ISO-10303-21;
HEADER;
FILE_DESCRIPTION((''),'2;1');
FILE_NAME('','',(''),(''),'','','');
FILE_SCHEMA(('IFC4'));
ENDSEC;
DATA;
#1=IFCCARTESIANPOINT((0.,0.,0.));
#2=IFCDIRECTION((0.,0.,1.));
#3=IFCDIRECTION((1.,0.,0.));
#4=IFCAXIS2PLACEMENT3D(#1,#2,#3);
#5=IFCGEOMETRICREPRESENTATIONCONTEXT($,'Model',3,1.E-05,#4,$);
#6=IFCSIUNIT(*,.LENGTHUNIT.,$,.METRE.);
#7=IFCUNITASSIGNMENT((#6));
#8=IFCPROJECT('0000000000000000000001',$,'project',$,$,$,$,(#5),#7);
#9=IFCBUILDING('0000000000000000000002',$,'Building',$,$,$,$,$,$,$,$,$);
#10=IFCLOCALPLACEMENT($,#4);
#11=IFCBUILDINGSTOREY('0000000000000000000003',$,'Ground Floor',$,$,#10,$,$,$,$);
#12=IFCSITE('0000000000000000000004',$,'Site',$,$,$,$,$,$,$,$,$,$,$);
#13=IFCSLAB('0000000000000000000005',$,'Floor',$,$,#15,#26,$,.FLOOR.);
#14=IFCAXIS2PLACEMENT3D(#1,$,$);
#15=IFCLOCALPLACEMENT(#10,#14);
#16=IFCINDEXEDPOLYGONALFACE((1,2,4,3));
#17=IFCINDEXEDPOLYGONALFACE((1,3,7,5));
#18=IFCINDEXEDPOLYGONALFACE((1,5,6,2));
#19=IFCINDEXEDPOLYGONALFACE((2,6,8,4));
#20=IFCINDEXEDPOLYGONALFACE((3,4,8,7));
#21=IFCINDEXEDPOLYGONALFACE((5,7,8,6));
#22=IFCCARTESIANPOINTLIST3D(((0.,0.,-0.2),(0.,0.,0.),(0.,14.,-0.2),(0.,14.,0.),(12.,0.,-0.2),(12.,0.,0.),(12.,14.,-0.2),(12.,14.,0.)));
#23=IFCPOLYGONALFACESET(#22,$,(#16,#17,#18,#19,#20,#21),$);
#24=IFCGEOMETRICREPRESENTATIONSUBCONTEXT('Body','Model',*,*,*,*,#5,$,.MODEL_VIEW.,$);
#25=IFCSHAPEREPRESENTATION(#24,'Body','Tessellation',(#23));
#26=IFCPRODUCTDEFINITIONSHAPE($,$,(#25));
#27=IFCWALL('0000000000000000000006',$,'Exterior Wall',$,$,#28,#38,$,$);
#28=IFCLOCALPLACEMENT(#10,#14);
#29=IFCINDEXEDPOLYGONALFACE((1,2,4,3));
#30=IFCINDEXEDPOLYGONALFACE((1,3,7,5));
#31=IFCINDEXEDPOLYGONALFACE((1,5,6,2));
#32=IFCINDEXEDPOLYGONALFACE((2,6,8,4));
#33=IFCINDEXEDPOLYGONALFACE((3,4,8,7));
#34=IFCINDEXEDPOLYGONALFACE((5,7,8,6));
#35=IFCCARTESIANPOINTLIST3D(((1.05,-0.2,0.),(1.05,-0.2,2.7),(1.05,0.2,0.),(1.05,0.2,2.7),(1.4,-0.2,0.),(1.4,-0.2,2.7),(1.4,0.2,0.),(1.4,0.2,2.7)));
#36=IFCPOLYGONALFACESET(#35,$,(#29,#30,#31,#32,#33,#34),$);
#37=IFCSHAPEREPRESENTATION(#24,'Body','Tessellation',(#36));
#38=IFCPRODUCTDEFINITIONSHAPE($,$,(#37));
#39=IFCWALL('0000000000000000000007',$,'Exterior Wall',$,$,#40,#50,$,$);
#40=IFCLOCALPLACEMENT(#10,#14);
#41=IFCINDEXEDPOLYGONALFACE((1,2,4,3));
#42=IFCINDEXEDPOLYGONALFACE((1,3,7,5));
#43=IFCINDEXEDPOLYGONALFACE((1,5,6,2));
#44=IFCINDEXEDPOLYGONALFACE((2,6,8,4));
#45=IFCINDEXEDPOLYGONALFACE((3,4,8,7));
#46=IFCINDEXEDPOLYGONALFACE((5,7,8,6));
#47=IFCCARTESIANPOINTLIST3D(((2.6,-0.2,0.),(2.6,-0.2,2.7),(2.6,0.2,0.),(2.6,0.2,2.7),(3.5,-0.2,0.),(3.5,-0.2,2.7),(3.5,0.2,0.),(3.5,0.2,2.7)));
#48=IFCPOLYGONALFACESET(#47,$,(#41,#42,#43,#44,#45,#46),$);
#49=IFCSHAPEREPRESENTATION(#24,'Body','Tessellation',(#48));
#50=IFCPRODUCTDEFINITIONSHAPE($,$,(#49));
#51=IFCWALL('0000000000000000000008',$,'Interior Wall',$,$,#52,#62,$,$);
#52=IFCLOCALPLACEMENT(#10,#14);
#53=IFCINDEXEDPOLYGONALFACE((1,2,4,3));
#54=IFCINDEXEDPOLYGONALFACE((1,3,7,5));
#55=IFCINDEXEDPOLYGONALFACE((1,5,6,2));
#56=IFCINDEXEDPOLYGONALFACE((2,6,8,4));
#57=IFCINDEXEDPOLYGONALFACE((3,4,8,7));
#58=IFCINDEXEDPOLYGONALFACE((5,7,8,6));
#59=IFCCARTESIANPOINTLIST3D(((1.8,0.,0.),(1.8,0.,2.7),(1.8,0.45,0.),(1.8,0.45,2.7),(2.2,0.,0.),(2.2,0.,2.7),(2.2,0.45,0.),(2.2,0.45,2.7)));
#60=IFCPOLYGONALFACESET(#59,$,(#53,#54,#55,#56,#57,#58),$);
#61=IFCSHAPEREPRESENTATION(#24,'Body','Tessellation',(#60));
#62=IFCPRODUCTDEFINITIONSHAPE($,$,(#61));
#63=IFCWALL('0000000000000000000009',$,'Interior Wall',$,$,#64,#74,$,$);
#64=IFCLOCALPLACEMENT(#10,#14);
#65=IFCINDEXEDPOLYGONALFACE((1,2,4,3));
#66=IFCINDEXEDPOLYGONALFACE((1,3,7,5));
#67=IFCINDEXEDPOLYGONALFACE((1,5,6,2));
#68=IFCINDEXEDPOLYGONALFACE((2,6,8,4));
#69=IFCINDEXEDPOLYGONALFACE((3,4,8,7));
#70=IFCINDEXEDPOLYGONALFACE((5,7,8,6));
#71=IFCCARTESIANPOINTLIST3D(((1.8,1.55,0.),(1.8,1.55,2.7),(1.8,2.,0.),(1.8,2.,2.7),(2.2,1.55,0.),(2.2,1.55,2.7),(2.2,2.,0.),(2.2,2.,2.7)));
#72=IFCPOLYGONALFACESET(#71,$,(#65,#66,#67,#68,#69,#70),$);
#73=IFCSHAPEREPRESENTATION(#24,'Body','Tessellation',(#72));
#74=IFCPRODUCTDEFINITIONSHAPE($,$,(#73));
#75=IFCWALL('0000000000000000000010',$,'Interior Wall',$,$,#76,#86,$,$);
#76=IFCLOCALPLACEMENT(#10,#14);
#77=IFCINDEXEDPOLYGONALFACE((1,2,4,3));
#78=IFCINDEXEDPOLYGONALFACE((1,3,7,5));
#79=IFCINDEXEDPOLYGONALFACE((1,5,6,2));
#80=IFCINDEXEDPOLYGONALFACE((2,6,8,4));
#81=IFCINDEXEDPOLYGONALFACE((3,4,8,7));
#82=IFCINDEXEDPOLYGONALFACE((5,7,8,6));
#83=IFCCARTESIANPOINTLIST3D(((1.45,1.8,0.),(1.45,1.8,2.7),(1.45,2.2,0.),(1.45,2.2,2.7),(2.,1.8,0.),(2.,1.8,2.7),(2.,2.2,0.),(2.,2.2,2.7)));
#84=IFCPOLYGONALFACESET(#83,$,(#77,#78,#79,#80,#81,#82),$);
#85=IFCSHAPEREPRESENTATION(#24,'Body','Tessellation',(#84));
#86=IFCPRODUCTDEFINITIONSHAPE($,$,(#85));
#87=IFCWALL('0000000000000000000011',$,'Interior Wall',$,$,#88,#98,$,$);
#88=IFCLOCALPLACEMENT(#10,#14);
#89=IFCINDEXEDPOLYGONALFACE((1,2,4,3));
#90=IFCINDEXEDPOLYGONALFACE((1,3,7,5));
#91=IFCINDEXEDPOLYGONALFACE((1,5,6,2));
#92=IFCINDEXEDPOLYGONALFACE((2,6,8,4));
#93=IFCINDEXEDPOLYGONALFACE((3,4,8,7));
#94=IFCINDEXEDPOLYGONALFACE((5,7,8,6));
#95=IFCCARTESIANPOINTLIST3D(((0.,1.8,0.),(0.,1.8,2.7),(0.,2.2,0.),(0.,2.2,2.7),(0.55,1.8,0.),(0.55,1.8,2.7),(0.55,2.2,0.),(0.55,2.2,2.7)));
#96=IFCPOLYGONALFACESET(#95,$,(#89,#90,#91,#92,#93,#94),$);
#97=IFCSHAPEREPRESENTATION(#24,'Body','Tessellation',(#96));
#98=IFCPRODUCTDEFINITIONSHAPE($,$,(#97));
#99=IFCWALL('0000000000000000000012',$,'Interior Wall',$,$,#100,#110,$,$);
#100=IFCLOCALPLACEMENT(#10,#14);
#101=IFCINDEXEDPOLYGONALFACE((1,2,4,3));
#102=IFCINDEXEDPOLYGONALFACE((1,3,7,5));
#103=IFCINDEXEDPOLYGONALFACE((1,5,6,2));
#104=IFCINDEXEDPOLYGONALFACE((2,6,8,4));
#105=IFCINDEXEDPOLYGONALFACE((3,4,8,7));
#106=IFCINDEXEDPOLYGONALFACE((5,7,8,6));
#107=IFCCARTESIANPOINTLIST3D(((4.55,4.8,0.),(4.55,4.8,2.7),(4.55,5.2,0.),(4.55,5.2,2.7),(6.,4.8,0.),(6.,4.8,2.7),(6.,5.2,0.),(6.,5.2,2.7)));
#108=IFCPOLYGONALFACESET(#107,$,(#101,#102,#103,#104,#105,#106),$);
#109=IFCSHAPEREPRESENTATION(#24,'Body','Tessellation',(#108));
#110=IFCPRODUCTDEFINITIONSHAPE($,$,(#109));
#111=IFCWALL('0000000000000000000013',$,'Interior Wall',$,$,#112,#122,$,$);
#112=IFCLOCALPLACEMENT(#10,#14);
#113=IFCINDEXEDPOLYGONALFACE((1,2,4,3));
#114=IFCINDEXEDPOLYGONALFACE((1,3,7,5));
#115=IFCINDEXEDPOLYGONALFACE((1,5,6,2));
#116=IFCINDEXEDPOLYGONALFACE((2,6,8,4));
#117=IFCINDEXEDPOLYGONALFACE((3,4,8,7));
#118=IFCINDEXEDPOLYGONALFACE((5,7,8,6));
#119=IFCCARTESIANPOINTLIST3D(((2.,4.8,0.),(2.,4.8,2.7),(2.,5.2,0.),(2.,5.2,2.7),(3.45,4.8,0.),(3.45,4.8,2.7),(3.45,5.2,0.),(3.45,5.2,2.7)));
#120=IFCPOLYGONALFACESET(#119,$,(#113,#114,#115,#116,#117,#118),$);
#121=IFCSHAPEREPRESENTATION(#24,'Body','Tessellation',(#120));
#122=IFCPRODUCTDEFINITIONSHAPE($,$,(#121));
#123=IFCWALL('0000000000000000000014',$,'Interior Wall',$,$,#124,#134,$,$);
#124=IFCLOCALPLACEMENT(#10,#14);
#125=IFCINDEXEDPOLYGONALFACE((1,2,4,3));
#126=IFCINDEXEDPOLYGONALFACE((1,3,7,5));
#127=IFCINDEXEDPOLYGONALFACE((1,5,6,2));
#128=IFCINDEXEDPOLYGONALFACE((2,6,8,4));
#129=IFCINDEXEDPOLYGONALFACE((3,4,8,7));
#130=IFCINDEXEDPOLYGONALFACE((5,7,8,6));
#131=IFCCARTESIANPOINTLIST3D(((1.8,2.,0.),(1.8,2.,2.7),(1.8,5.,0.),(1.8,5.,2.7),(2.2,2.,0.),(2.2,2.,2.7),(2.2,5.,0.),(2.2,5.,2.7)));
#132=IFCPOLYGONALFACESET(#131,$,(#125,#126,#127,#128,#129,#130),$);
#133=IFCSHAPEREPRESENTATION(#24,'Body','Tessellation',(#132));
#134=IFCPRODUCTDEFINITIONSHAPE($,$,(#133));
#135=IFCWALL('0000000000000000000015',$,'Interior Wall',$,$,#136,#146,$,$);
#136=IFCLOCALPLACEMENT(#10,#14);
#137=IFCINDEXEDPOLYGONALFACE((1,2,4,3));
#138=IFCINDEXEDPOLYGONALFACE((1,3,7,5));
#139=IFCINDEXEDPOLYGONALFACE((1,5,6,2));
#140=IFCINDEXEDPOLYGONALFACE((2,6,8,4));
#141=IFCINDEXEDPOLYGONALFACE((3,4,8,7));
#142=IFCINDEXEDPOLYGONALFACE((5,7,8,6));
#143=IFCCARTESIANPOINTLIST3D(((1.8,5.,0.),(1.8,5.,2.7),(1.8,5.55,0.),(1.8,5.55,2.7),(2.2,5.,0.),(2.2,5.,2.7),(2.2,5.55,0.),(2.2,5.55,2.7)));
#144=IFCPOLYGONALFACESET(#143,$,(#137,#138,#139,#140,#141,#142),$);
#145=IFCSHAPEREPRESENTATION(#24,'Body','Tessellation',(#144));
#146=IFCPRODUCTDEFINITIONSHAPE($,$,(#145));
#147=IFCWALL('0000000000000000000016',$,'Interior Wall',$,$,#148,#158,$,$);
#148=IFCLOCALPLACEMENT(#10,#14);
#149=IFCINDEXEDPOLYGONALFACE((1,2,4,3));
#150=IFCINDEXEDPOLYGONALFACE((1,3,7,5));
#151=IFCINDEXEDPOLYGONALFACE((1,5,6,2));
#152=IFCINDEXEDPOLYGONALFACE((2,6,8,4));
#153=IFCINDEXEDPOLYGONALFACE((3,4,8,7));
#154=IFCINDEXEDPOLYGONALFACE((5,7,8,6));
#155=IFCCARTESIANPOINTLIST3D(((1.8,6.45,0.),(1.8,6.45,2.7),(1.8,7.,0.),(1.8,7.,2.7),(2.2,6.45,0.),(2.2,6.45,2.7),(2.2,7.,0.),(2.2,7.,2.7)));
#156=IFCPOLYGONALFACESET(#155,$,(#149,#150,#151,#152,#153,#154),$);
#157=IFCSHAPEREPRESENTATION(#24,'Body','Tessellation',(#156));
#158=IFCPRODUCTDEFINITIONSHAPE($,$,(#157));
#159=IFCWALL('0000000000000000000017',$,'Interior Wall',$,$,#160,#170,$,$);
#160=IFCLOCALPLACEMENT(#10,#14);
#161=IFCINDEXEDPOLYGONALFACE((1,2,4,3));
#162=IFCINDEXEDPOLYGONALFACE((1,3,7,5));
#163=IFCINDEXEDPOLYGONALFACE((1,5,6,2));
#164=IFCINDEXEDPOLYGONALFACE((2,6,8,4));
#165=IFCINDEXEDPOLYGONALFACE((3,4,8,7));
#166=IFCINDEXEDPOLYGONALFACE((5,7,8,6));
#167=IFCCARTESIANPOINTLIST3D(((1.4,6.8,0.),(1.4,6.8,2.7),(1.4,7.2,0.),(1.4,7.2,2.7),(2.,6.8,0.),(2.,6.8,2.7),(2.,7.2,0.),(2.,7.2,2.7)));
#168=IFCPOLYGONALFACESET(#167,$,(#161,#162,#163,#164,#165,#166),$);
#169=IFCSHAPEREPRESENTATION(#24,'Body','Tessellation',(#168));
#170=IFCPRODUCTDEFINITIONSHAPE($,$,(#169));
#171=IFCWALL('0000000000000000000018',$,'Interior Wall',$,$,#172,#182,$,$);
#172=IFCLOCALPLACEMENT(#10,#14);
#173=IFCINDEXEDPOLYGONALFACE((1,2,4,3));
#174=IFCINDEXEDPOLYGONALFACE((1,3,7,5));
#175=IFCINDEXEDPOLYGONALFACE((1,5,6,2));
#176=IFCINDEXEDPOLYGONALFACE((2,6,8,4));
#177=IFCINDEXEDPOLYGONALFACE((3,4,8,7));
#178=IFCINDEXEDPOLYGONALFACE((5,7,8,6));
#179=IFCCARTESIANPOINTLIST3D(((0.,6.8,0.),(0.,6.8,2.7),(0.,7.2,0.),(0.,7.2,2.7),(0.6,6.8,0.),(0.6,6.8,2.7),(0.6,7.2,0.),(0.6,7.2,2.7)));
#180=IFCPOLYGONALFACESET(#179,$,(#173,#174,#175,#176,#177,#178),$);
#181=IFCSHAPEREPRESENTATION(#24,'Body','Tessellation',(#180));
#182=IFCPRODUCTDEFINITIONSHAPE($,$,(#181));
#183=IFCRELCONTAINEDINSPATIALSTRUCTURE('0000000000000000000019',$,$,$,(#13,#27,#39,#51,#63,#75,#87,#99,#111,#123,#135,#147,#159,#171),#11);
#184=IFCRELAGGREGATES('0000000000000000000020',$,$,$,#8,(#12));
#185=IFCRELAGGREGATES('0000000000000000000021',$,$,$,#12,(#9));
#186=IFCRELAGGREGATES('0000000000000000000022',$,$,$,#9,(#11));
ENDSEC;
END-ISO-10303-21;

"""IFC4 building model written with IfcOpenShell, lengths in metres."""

from ifc_helpers import new_model, si_unit, frame, origin_with_axes, place, context, subcontext, project, spatial, indexed_curve, outline, extrude, element, save


model = new_model("IFC4")

# Units and contexts
model_context = context("Model", 3, precision=1e-05, world=origin_with_axes())
body_context = subcontext(model_context, "Body", "Model", "MODEL_VIEW")
ifc_project = project(units=[si_unit("LENGTHUNIT", "METRE")], contexts=[model_context])

# Site, building, storey
site = spatial("IfcSite", under=ifc_project, Name="Site")
building = spatial("IfcBuilding", under=site, Name="Building")
storey_placement = place(None, origin_with_axes())
storey = spatial("IfcBuildingStorey", under=building, at=storey_placement, Name="Ground Floor")

# Slab
slab_placement = place(storey_placement, frame((0.0, 0.0, -0.2), z_axis=(0.0, 0.0, 1.0), x_axis=(1.0, 0.0, 0.0)))
element("IfcSlab", 1, at=slab_placement, inside=storey, Name="Floor", PredefinedType="FLOOR", context=body_context, shape_type="SweptSolid", body=[
    extrude(outline(indexed_curve([(0.0, 0.0), (12.0, 0.0), (12.0, 14.0), (0.0, 14.0)])), None, (0.0, 0.0, 1.0), 0.2),
])

# Walls
wall_1_placement = place(storey_placement, frame((1.05, 0.0, 0.0), z_axis=(0.0, 0.0, 1.0), x_axis=(1.0, 0.0, 0.0)))
element("IfcWall", 2, at=wall_1_placement, inside=storey, Name="Exterior Wall", context=body_context, shape_type="SweptSolid", body=[
    extrude(outline(indexed_curve([(0.0, 0.0), (0.0, 0.4), (0.35, 0.4), (0.35, 0.0), (0.0, 0.0)], self_intersect=False)), frame((0.0, -0.2, 0.0), z_axis=(0.0, 0.0, 1.0), x_axis=(1.0, 0.0, 0.0)), (0.0, 0.0, 1.0), 2.7),
])
wall_2_placement = place(storey_placement, frame((2.6, 0.0, 0.0), z_axis=(0.0, 0.0, 1.0), x_axis=(1.0, 0.0, 0.0)))
element("IfcWall", 3, at=wall_2_placement, inside=storey, Name="Exterior Wall", context=body_context, shape_type="SweptSolid", body=[
    extrude(outline(indexed_curve([(0.0, 0.0), (0.0, 0.4), (0.9, 0.4), (0.9, 0.0), (0.0, 0.0)], self_intersect=False)), frame((0.0, -0.2, 0.0), z_axis=(0.0, 0.0, 1.0), x_axis=(1.0, 0.0, 0.0)), (0.0, 0.0, 1.0), 2.7),
])
for number, where, z_axis, x_axis, name in (
    (4, (2.0, 0.0, 0.0), (0.0, 0.0, 1.0), (0.0, 1.0, 0.0), "Interior Wall"),
    (5, (2.0, 1.55, 0.0), (0.0, 0.0, 1.0), (0.0, 1.0, 0.0), "Interior Wall"),
):
    element("IfcWall", number, at=place(storey_placement, frame(where, z_axis=z_axis, x_axis=x_axis)), inside=storey, Name=name, context=body_context, shape_type="SweptSolid", body=[
        extrude(outline(indexed_curve([(0.0, 0.0), (0.0, 0.4), (0.45, 0.4), (0.45, 0.0), (0.0, 0.0)], self_intersect=False)), frame((0.0, -0.2, 0.0), z_axis=(0.0, 0.0, 1.0), x_axis=(1.0, 0.0, 0.0)), (0.0, 0.0, 1.0), 2.7),
    ])
for number, where, z_axis, x_axis, name in (
    (6, (2.0, 2.0, 0.0), (0.0, 0.0, 1.0), (-1.0, 0.0, 0.0), "Interior Wall"),
    (7, (0.55, 2.0, 0.0), (0.0, 0.0, 1.0), (-1.0, 0.0, 0.0), "Interior Wall"),
):
    element("IfcWall", number, at=place(storey_placement, frame(where, z_axis=z_axis, x_axis=x_axis)), inside=storey, Name=name, context=body_context, shape_type="SweptSolid", body=[
        extrude(outline(indexed_curve([(0.0, 0.0), (0.0, 0.4), (0.55, 0.4), (0.55, 0.0), (0.0, 0.0)], self_intersect=False)), frame((0.0, -0.2, 0.0), z_axis=(0.0, 0.0, 1.0), x_axis=(1.0, 0.0, 0.0)), (0.0, 0.0, 1.0), 2.7),
    ])
for number, where, z_axis, x_axis, name in (
    (8, (6.0, 5.0, 0.0), (0.0, 0.0, 1.0), (-1.0, 0.0, 0.0), "Interior Wall"),
    (9, (3.45, 5.0, 0.0), (0.0, 0.0, 1.0), (-1.0, 0.0, 0.0), "Interior Wall"),
):
    element("IfcWall", number, at=place(storey_placement, frame(where, z_axis=z_axis, x_axis=x_axis)), inside=storey, Name=name, context=body_context, shape_type="SweptSolid", body=[
        extrude(outline(indexed_curve([(0.0, 0.0), (0.0, 0.4), (1.45, 0.4), (1.45, 0.0), (0.0, 0.0)], self_intersect=False)), frame((0.0, -0.2, 0.0), z_axis=(0.0, 0.0, 1.0), x_axis=(1.0, 0.0, 0.0)), (0.0, 0.0, 1.0), 2.7),
    ])
wall_3_placement = place(storey_placement, frame((2.0, 5.0, 0.0), z_axis=(0.0, 0.0, 1.0), x_axis=(0.0, -1.0, 0.0)))
element("IfcWall", 10, at=wall_3_placement, inside=storey, Name="Interior Wall", context=body_context, shape_type="SweptSolid", body=[
    extrude(outline(indexed_curve([(0.0, 0.0), (0.0, 0.4), (3.0, 0.4), (3.0, 0.0), (0.0, 0.0)], self_intersect=False)), frame((0.0, -0.2, 0.0), z_axis=(0.0, 0.0, 1.0), x_axis=(1.0, 0.0, 0.0)), (0.0, 0.0, 1.0), 2.7),
])
for number, where, z_axis, x_axis, name in (
    (11, (2.0, 5.0, 0.0), (0.0, 0.0, 1.0), (0.0, 1.0, 0.0), "Interior Wall"),
    (12, (2.0, 6.45, 0.0), (0.0, 0.0, 1.0), (0.0, 1.0, 0.0), "Interior Wall"),
):
    element("IfcWall", number, at=place(storey_placement, frame(where, z_axis=z_axis, x_axis=x_axis)), inside=storey, Name=name, context=body_context, shape_type="SweptSolid", body=[
        extrude(outline(indexed_curve([(0.0, 0.0), (0.0, 0.4), (0.55, 0.4), (0.55, 0.0), (0.0, 0.0)], self_intersect=False)), frame((0.0, -0.2, 0.0), z_axis=(0.0, 0.0, 1.0), x_axis=(1.0, 0.0, 0.0)), (0.0, 0.0, 1.0), 2.7),
    ])
for number, where, z_axis, x_axis, name in (
    (13, (2.0, 7.0, 0.0), (0.0, 0.0, 1.0), (-1.0, 0.0, 0.0), "Interior Wall"),
    (14, (0.6, 7.0, 0.0), (0.0, 0.0, 1.0), (-1.0, 0.0, 0.0), "Interior Wall"),
):
    element("IfcWall", number, at=place(storey_placement, frame(where, z_axis=z_axis, x_axis=x_axis)), inside=storey, Name=name, context=body_context, shape_type="SweptSolid", body=[
        extrude(outline(indexed_curve([(0.0, 0.0), (0.0, 0.4), (0.6, 0.4), (0.6, 0.0), (0.0, 0.0)], self_intersect=False)), frame((0.0, -0.2, 0.0), z_axis=(0.0, 0.0, 1.0), x_axis=(1.0, 0.0, 0.0)), (0.0, 0.0, 1.0), 2.7),
    ])

save(model, "model.ifc")
